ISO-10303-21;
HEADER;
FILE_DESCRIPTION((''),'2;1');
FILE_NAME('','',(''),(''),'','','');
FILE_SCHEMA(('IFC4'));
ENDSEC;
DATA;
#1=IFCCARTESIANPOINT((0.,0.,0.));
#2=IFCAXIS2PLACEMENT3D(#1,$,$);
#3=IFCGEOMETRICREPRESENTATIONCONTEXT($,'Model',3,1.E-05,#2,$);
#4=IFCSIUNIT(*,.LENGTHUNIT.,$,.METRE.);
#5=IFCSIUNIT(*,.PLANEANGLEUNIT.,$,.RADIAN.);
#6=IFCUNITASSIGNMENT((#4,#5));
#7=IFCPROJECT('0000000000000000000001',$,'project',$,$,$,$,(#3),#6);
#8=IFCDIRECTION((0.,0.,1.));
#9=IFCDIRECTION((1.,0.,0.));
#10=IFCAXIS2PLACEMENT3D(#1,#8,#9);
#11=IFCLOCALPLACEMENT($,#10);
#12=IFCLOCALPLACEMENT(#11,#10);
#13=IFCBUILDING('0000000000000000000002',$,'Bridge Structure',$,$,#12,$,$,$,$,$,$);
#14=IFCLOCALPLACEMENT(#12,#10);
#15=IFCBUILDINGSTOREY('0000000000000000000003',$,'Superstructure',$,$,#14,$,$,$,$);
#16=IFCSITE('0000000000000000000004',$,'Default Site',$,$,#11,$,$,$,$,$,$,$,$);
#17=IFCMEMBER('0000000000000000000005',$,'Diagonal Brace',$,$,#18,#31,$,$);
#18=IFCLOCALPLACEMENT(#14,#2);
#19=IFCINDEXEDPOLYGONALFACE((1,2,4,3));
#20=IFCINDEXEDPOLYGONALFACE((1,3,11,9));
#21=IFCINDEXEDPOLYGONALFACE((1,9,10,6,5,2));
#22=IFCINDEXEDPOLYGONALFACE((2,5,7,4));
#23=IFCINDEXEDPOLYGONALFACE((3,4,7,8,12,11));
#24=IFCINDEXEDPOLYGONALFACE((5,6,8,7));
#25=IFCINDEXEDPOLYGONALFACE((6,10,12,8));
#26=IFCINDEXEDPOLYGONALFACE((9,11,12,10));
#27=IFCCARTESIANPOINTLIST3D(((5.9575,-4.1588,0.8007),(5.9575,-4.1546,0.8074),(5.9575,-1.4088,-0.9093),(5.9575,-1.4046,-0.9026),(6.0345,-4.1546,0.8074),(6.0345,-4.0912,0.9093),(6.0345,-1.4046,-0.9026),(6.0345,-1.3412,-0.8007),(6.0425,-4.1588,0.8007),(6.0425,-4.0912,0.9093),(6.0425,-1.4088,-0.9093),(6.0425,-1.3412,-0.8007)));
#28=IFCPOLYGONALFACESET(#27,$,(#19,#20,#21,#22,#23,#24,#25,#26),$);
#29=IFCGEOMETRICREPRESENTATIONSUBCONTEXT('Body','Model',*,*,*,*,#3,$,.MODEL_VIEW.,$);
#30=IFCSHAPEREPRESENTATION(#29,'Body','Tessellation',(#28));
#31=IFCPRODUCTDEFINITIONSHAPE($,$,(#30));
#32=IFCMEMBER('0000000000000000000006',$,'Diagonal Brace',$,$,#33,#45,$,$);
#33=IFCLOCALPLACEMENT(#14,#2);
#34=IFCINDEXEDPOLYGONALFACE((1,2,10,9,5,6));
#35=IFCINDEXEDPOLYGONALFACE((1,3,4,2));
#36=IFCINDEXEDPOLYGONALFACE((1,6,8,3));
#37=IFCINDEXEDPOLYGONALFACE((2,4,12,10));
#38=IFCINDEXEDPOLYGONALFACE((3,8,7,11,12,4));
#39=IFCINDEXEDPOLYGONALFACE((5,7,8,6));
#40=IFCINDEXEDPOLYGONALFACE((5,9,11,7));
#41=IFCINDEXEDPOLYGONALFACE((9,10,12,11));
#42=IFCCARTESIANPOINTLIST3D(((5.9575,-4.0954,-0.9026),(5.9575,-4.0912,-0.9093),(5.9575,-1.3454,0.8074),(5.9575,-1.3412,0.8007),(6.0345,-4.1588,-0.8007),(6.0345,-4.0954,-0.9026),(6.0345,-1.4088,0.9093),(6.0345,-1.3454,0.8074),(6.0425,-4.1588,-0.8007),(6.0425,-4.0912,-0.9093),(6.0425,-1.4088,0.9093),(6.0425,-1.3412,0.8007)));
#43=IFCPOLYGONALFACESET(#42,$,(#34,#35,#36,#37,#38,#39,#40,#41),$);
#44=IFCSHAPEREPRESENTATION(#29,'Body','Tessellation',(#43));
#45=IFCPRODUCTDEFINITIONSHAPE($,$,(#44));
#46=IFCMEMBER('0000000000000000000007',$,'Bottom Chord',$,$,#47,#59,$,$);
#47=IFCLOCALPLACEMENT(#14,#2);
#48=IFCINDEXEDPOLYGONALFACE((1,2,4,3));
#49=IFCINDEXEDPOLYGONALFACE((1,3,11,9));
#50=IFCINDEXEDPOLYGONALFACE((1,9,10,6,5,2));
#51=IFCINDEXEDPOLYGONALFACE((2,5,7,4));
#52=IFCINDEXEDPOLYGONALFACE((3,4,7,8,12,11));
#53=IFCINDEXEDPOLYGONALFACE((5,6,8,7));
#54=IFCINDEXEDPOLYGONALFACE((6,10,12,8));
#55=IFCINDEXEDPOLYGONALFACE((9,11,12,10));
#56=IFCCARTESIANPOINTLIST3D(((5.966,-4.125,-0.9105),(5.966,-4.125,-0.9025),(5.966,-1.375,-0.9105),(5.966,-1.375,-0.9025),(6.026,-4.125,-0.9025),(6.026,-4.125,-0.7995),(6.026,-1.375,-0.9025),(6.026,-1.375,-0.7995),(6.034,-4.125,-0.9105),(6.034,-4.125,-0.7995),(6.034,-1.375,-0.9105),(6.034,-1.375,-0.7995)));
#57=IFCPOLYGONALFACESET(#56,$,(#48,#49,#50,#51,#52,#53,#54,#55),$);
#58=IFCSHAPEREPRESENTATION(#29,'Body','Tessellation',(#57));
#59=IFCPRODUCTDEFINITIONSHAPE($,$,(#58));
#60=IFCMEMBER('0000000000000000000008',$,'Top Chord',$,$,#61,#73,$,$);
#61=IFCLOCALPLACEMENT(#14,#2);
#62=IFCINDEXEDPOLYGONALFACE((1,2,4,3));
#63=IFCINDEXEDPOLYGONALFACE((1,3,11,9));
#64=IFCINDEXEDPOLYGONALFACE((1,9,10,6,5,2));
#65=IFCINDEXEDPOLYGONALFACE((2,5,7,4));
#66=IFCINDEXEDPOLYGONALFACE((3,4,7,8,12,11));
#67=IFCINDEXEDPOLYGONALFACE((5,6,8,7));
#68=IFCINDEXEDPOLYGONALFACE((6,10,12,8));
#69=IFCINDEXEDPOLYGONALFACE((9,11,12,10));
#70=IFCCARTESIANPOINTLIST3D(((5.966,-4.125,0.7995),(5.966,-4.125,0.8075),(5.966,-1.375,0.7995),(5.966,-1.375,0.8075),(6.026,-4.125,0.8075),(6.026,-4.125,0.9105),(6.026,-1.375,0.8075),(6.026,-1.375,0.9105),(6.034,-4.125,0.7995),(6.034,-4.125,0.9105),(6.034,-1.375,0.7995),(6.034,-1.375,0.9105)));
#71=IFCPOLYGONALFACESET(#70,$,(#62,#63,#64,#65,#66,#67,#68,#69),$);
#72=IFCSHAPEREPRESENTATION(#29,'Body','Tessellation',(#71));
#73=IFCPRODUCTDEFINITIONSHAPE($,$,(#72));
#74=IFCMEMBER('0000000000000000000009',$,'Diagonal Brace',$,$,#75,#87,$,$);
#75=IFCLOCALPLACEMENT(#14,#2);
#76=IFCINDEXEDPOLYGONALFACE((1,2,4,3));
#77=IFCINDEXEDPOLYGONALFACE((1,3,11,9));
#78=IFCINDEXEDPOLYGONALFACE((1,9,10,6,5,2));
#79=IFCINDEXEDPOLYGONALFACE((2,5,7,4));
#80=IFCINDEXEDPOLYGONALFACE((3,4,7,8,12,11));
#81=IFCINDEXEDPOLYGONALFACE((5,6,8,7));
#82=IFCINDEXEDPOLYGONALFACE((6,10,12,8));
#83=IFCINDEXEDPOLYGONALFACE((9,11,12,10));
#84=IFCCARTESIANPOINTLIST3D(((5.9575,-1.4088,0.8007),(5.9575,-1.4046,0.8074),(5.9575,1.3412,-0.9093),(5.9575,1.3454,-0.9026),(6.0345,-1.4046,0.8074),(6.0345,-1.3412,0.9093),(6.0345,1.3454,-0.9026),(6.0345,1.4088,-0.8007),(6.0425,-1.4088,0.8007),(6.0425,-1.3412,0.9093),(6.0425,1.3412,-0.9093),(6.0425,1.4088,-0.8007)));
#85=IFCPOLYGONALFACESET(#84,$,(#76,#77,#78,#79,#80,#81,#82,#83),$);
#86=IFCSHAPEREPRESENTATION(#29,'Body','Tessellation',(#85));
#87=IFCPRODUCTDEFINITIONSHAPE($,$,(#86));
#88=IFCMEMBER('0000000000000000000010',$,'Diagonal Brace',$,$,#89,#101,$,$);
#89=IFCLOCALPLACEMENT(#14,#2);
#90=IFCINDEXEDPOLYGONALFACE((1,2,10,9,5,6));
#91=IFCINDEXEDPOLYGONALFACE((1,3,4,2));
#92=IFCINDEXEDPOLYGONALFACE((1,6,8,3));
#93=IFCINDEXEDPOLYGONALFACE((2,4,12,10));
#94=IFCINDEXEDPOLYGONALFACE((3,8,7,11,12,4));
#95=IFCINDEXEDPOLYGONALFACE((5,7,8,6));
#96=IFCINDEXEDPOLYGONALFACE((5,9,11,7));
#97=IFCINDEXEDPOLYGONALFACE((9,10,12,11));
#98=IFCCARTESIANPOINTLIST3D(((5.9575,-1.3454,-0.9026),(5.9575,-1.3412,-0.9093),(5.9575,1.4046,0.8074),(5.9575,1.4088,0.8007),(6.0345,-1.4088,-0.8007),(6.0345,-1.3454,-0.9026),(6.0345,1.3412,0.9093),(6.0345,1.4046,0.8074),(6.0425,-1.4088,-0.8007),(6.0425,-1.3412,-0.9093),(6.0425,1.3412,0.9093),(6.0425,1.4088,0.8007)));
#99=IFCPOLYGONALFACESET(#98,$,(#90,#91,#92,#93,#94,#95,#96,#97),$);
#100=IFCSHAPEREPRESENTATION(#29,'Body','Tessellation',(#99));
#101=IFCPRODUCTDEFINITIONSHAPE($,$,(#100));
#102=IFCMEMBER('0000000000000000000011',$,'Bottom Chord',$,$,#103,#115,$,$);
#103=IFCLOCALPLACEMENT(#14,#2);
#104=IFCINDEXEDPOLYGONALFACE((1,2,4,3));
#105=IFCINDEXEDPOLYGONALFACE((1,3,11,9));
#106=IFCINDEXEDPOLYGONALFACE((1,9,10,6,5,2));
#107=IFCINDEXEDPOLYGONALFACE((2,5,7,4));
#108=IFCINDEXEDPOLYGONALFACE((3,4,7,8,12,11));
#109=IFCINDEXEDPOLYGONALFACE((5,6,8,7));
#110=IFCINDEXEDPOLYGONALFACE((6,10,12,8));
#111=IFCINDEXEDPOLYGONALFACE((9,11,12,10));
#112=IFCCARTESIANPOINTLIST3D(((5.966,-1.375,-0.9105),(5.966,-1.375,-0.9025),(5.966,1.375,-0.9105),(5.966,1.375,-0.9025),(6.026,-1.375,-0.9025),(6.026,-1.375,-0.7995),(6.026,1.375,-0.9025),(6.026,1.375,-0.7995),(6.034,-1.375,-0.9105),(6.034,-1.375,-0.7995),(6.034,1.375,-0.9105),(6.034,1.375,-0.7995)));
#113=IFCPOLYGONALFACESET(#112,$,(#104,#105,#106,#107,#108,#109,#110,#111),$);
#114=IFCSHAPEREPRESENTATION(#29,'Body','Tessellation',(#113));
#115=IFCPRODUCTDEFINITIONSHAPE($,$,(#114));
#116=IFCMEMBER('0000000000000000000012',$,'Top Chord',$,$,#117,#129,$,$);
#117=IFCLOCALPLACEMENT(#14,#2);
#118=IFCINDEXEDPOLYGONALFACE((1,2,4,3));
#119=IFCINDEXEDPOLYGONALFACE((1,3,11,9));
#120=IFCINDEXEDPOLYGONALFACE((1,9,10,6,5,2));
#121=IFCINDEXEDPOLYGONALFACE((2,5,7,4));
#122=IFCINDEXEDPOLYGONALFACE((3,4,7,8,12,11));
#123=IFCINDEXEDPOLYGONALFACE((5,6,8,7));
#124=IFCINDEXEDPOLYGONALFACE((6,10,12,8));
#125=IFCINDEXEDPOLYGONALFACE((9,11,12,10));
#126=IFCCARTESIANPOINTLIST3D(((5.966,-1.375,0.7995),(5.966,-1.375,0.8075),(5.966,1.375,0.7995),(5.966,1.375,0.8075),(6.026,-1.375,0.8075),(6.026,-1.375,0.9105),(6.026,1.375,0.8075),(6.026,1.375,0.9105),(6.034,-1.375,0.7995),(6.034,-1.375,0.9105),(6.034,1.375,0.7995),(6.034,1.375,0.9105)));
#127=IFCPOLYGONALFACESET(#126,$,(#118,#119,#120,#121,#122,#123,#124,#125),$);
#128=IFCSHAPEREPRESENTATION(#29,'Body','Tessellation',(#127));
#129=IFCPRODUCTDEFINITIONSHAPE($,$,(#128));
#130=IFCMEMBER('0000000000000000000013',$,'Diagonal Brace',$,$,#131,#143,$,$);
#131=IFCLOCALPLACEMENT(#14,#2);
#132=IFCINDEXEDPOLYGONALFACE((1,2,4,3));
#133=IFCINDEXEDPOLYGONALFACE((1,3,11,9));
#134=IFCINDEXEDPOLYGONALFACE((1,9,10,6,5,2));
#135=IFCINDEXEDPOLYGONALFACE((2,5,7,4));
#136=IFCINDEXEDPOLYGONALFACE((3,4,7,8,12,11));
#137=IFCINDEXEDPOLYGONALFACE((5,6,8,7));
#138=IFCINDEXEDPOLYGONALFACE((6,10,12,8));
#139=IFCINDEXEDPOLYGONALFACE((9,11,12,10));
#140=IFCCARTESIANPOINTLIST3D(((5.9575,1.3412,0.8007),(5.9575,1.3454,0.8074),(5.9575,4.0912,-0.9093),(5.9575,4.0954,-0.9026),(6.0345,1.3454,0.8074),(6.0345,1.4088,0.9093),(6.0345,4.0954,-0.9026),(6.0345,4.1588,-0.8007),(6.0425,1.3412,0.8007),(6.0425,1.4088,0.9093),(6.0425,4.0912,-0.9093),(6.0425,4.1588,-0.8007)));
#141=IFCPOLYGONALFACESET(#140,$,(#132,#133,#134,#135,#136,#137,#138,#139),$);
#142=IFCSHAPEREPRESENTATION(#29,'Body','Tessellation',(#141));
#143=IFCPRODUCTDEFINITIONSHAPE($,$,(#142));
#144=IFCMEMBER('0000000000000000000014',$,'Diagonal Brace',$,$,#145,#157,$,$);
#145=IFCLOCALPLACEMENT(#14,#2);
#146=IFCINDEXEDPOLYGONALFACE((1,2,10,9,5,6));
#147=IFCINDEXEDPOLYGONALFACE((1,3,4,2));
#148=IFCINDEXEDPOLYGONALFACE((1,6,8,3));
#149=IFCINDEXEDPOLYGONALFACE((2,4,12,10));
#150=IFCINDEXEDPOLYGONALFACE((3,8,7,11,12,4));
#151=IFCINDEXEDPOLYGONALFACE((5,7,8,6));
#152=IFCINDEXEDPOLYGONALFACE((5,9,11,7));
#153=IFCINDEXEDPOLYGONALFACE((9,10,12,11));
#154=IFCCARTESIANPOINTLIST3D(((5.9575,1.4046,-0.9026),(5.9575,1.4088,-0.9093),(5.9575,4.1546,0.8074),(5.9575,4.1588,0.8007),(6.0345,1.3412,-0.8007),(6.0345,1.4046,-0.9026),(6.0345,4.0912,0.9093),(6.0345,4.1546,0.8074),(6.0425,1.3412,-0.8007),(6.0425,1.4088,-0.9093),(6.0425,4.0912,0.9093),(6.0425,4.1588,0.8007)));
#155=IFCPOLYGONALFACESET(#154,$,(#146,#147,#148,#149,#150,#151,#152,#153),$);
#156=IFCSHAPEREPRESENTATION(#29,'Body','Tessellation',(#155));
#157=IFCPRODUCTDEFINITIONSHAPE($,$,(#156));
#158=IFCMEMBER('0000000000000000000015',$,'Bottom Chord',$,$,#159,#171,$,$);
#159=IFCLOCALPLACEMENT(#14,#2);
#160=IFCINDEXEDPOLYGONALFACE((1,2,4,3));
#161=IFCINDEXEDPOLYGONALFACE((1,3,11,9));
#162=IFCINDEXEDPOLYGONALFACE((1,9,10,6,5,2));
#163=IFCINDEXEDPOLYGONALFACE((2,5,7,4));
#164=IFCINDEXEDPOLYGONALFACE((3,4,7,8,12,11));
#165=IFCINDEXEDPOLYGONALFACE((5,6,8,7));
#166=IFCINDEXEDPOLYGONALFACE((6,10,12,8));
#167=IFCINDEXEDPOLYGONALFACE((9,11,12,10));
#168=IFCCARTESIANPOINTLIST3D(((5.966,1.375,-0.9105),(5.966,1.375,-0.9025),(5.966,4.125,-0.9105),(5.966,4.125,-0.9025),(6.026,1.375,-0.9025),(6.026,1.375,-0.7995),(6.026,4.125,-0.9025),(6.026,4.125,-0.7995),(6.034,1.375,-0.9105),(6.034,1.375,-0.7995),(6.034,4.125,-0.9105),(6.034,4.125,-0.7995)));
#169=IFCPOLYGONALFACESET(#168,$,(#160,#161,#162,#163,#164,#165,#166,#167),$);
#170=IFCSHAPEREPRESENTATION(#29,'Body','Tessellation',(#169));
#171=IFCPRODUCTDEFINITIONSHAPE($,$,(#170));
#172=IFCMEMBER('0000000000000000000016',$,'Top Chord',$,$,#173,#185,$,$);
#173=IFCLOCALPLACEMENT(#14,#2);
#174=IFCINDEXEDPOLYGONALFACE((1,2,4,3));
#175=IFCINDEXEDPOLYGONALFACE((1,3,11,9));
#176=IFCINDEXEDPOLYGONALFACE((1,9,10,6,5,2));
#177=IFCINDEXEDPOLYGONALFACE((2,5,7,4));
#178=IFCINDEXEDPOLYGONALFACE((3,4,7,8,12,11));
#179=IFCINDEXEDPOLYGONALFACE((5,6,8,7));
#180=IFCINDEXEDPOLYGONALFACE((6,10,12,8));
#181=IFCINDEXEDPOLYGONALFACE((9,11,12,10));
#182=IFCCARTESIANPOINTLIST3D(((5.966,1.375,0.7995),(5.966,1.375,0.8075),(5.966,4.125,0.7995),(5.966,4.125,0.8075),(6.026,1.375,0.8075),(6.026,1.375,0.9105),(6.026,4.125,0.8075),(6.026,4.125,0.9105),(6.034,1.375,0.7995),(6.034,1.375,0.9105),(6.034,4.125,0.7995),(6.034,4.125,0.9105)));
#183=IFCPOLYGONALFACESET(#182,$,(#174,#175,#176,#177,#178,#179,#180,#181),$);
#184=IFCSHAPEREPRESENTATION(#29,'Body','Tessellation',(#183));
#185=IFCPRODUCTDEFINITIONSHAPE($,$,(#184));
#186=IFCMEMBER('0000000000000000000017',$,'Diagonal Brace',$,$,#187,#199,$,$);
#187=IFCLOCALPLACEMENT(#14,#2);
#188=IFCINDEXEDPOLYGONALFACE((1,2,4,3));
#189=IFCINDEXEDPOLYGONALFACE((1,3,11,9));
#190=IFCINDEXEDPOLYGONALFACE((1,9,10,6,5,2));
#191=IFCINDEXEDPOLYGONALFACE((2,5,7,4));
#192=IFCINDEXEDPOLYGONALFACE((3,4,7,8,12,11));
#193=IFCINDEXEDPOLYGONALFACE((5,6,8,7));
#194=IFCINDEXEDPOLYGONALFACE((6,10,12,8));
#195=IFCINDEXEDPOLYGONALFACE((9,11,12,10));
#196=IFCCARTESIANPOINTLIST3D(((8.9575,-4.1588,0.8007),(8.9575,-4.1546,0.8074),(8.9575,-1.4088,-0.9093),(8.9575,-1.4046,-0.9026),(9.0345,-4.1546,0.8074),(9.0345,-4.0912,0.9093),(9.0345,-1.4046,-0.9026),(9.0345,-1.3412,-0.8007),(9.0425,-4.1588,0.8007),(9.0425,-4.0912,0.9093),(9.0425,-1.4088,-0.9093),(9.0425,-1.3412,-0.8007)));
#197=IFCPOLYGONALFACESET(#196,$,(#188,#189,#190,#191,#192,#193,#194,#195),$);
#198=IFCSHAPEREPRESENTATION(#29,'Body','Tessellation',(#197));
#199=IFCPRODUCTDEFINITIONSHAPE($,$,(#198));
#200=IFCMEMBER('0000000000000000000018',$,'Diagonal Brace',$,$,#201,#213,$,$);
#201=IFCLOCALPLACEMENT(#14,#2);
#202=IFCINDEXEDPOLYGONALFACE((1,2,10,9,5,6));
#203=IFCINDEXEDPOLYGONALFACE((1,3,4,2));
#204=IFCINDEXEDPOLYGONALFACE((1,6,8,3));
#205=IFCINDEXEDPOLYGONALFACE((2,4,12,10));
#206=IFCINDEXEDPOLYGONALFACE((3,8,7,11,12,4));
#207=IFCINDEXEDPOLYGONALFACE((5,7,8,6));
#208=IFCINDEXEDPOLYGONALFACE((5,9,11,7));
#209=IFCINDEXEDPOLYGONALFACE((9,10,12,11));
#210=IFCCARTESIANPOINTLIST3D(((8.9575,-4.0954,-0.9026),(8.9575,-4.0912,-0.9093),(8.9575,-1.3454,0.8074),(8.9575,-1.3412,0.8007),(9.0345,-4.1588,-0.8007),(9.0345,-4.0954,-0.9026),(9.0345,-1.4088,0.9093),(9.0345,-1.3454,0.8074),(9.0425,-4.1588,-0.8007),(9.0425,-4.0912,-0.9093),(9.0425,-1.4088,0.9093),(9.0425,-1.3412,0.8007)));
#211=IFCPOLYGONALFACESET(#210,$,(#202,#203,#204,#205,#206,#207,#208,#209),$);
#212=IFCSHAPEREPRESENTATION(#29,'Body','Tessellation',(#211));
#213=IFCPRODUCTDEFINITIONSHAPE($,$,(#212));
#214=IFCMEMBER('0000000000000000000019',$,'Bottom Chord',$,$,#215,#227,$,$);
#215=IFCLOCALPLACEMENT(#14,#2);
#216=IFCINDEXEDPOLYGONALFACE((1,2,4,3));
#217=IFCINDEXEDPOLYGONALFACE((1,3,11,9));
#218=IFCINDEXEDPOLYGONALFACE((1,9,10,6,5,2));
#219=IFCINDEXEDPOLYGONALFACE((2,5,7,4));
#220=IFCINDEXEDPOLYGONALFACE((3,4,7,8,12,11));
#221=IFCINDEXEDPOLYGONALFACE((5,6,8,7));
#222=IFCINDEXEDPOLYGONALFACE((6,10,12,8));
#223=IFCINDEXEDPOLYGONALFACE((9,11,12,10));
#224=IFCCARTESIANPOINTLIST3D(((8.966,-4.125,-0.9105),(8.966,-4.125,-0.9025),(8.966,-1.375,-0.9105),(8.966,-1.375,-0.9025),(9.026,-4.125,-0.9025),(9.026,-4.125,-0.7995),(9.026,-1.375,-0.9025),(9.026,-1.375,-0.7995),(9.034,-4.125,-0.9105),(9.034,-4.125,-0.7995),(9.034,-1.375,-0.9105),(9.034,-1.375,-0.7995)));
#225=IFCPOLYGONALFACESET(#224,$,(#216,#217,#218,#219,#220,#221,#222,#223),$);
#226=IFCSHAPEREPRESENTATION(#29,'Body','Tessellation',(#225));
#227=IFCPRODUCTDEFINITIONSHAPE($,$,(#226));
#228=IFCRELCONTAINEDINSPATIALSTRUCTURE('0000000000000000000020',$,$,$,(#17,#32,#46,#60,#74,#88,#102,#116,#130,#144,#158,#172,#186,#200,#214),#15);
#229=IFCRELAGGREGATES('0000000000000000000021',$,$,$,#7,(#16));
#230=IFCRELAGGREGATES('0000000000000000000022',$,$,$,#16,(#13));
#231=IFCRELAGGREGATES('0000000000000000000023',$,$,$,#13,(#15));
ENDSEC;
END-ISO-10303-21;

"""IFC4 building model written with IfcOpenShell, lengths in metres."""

from ifc_helpers import new_model, si_unit, frame, origin, origin_with_axes, origin_2d_with_axis, place, context, subcontext, project, spatial, l_section, extrude, element, save


model = new_model("IFC4")

# Units and contexts
model_context = context("Model", 3, precision=1e-05, world=origin())
body_context = subcontext(model_context, "Body", "Model", "MODEL_VIEW")
ifc_project = project(units=[si_unit("LENGTHUNIT", "METRE"), si_unit("PLANEANGLEUNIT", "RADIAN")], contexts=[model_context])

# Site, building, storey
site_placement = place(None, origin_with_axes())
site = spatial("IfcSite", under=ifc_project, at=site_placement, Name="Default Site")
building_placement = place(site_placement, origin_with_axes())
building = spatial("IfcBuilding", under=site, at=building_placement, Name="Bridge Structure")
storey_placement = place(building_placement, origin_with_axes())
storey = spatial("IfcBuildingStorey", under=building, at=storey_placement, Name="Superstructure")

# Members
for number, where, z_axis, x_axis, name in (
    (1, (6.0, -4.125, 0.855), (0.0, 0.84921, -0.528055), (-1.0, 0.0, 0.0), "Diagonal Brace"),
    (2, (6.0, -4.125, -0.855), (0.0, 0.84921, 0.528055), (-1.0, 0.0, 0.0), "Diagonal Brace"),
):
    element("IfcMember", number, at=place(storey_placement, frame(where, z_axis=z_axis, x_axis=x_axis)), inside=storey, Name=name, context=body_context, shape_type="SweptSolid", body=[
        extrude(l_section(Depth=0.128, Width=0.085, Thickness=0.008, at=origin_2d_with_axis()), origin_with_axes(), (0.0, 0.0, 1.0), 3.2383),
    ])
for number, where, z_axis, x_axis, name in (
    (3, (6.0, -4.125, -0.855), (0.0, 1.0, 0.0), (-1.0, 0.0, 0.0), "Bottom Chord"),
    (4, (6.0, -4.125, 0.855), (0.0, 1.0, 0.0), (-1.0, 0.0, 0.0), "Top Chord"),
):
    element("IfcMember", number, at=place(storey_placement, frame(where, z_axis=z_axis, x_axis=x_axis)), inside=storey, Name=name, context=body_context, shape_type="SweptSolid", body=[
        extrude(l_section(Depth=0.111, Width=0.068, Thickness=0.008, at=origin_2d_with_axis()), origin_with_axes(), (0.0, 0.0, 1.0), 2.75),
    ])
for number, where, z_axis, x_axis, name in (
    (5, (6.0, -1.375, 0.855), (0.0, 0.84921, -0.528055), (-1.0, 0.0, 0.0), "Diagonal Brace"),
    (6, (6.0, -1.375, -0.855), (0.0, 0.84921, 0.528055), (-1.0, 0.0, 0.0), "Diagonal Brace"),
):
    element("IfcMember", number, at=place(storey_placement, frame(where, z_axis=z_axis, x_axis=x_axis)), inside=storey, Name=name, context=body_context, shape_type="SweptSolid", body=[
        extrude(l_section(Depth=0.128, Width=0.085, Thickness=0.008, at=origin_2d_with_axis()), origin_with_axes(), (0.0, 0.0, 1.0), 3.2383),
    ])
for number, where, z_axis, x_axis, name in (
    (7, (6.0, -1.375, -0.855), (0.0, 1.0, 0.0), (-1.0, 0.0, 0.0), "Bottom Chord"),
    (8, (6.0, -1.375, 0.855), (0.0, 1.0, 0.0), (-1.0, 0.0, 0.0), "Top Chord"),
):
    element("IfcMember", number, at=place(storey_placement, frame(where, z_axis=z_axis, x_axis=x_axis)), inside=storey, Name=name, context=body_context, shape_type="SweptSolid", body=[
        extrude(l_section(Depth=0.111, Width=0.068, Thickness=0.008, at=origin_2d_with_axis()), origin_with_axes(), (0.0, 0.0, 1.0), 2.75),
    ])
for number, where, z_axis, x_axis, name in (
    (9, (6.0, 1.375, 0.855), (0.0, 0.84921, -0.528055), (-1.0, 0.0, 0.0), "Diagonal Brace"),
    (10, (6.0, 1.375, -0.855), (0.0, 0.84921, 0.528055), (-1.0, 0.0, 0.0), "Diagonal Brace"),
):
    element("IfcMember", number, at=place(storey_placement, frame(where, z_axis=z_axis, x_axis=x_axis)), inside=storey, Name=name, context=body_context, shape_type="SweptSolid", body=[
        extrude(l_section(Depth=0.128, Width=0.085, Thickness=0.008, at=origin_2d_with_axis()), origin_with_axes(), (0.0, 0.0, 1.0), 3.2383),
    ])
for number, where, z_axis, x_axis, name in (
    (11, (6.0, 1.375, -0.855), (0.0, 1.0, 0.0), (-1.0, 0.0, 0.0), "Bottom Chord"),
    (12, (6.0, 1.375, 0.855), (0.0, 1.0, 0.0), (-1.0, 0.0, 0.0), "Top Chord"),
):
    element("IfcMember", number, at=place(storey_placement, frame(where, z_axis=z_axis, x_axis=x_axis)), inside=storey, Name=name, context=body_context, shape_type="SweptSolid", body=[
        extrude(l_section(Depth=0.111, Width=0.068, Thickness=0.008, at=origin_2d_with_axis()), origin_with_axes(), (0.0, 0.0, 1.0), 2.75),
    ])
for number, where, z_axis, x_axis, name in (
    (13, (9.0, -4.125, 0.855), (0.0, 0.84921, -0.528055), (-1.0, 0.0, 0.0), "Diagonal Brace"),
    (14, (9.0, -4.125, -0.855), (0.0, 0.84921, 0.528055), (-1.0, 0.0, 0.0), "Diagonal Brace"),
):
    element("IfcMember", number, at=place(storey_placement, frame(where, z_axis=z_axis, x_axis=x_axis)), inside=storey, Name=name, context=body_context, shape_type="SweptSolid", body=[
        extrude(l_section(Depth=0.128, Width=0.085, Thickness=0.008, at=origin_2d_with_axis()), origin_with_axes(), (0.0, 0.0, 1.0), 3.2383),
    ])
for number, where, z_axis, x_axis, name in (
    (15, (9.0, -4.125, -0.855), (0.0, 1.0, 0.0), (-1.0, 0.0, 0.0), "Bottom Chord"),
):
    element("IfcMember", number, at=place(storey_placement, frame(where, z_axis=z_axis, x_axis=x_axis)), inside=storey, Name=name, context=body_context, shape_type="SweptSolid", body=[
        extrude(l_section(Depth=0.111, Width=0.068, Thickness=0.008, at=origin_2d_with_axis()), origin_with_axes(), (0.0, 0.0, 1.0), 2.75),
    ])

save(model, "model.ifc")
